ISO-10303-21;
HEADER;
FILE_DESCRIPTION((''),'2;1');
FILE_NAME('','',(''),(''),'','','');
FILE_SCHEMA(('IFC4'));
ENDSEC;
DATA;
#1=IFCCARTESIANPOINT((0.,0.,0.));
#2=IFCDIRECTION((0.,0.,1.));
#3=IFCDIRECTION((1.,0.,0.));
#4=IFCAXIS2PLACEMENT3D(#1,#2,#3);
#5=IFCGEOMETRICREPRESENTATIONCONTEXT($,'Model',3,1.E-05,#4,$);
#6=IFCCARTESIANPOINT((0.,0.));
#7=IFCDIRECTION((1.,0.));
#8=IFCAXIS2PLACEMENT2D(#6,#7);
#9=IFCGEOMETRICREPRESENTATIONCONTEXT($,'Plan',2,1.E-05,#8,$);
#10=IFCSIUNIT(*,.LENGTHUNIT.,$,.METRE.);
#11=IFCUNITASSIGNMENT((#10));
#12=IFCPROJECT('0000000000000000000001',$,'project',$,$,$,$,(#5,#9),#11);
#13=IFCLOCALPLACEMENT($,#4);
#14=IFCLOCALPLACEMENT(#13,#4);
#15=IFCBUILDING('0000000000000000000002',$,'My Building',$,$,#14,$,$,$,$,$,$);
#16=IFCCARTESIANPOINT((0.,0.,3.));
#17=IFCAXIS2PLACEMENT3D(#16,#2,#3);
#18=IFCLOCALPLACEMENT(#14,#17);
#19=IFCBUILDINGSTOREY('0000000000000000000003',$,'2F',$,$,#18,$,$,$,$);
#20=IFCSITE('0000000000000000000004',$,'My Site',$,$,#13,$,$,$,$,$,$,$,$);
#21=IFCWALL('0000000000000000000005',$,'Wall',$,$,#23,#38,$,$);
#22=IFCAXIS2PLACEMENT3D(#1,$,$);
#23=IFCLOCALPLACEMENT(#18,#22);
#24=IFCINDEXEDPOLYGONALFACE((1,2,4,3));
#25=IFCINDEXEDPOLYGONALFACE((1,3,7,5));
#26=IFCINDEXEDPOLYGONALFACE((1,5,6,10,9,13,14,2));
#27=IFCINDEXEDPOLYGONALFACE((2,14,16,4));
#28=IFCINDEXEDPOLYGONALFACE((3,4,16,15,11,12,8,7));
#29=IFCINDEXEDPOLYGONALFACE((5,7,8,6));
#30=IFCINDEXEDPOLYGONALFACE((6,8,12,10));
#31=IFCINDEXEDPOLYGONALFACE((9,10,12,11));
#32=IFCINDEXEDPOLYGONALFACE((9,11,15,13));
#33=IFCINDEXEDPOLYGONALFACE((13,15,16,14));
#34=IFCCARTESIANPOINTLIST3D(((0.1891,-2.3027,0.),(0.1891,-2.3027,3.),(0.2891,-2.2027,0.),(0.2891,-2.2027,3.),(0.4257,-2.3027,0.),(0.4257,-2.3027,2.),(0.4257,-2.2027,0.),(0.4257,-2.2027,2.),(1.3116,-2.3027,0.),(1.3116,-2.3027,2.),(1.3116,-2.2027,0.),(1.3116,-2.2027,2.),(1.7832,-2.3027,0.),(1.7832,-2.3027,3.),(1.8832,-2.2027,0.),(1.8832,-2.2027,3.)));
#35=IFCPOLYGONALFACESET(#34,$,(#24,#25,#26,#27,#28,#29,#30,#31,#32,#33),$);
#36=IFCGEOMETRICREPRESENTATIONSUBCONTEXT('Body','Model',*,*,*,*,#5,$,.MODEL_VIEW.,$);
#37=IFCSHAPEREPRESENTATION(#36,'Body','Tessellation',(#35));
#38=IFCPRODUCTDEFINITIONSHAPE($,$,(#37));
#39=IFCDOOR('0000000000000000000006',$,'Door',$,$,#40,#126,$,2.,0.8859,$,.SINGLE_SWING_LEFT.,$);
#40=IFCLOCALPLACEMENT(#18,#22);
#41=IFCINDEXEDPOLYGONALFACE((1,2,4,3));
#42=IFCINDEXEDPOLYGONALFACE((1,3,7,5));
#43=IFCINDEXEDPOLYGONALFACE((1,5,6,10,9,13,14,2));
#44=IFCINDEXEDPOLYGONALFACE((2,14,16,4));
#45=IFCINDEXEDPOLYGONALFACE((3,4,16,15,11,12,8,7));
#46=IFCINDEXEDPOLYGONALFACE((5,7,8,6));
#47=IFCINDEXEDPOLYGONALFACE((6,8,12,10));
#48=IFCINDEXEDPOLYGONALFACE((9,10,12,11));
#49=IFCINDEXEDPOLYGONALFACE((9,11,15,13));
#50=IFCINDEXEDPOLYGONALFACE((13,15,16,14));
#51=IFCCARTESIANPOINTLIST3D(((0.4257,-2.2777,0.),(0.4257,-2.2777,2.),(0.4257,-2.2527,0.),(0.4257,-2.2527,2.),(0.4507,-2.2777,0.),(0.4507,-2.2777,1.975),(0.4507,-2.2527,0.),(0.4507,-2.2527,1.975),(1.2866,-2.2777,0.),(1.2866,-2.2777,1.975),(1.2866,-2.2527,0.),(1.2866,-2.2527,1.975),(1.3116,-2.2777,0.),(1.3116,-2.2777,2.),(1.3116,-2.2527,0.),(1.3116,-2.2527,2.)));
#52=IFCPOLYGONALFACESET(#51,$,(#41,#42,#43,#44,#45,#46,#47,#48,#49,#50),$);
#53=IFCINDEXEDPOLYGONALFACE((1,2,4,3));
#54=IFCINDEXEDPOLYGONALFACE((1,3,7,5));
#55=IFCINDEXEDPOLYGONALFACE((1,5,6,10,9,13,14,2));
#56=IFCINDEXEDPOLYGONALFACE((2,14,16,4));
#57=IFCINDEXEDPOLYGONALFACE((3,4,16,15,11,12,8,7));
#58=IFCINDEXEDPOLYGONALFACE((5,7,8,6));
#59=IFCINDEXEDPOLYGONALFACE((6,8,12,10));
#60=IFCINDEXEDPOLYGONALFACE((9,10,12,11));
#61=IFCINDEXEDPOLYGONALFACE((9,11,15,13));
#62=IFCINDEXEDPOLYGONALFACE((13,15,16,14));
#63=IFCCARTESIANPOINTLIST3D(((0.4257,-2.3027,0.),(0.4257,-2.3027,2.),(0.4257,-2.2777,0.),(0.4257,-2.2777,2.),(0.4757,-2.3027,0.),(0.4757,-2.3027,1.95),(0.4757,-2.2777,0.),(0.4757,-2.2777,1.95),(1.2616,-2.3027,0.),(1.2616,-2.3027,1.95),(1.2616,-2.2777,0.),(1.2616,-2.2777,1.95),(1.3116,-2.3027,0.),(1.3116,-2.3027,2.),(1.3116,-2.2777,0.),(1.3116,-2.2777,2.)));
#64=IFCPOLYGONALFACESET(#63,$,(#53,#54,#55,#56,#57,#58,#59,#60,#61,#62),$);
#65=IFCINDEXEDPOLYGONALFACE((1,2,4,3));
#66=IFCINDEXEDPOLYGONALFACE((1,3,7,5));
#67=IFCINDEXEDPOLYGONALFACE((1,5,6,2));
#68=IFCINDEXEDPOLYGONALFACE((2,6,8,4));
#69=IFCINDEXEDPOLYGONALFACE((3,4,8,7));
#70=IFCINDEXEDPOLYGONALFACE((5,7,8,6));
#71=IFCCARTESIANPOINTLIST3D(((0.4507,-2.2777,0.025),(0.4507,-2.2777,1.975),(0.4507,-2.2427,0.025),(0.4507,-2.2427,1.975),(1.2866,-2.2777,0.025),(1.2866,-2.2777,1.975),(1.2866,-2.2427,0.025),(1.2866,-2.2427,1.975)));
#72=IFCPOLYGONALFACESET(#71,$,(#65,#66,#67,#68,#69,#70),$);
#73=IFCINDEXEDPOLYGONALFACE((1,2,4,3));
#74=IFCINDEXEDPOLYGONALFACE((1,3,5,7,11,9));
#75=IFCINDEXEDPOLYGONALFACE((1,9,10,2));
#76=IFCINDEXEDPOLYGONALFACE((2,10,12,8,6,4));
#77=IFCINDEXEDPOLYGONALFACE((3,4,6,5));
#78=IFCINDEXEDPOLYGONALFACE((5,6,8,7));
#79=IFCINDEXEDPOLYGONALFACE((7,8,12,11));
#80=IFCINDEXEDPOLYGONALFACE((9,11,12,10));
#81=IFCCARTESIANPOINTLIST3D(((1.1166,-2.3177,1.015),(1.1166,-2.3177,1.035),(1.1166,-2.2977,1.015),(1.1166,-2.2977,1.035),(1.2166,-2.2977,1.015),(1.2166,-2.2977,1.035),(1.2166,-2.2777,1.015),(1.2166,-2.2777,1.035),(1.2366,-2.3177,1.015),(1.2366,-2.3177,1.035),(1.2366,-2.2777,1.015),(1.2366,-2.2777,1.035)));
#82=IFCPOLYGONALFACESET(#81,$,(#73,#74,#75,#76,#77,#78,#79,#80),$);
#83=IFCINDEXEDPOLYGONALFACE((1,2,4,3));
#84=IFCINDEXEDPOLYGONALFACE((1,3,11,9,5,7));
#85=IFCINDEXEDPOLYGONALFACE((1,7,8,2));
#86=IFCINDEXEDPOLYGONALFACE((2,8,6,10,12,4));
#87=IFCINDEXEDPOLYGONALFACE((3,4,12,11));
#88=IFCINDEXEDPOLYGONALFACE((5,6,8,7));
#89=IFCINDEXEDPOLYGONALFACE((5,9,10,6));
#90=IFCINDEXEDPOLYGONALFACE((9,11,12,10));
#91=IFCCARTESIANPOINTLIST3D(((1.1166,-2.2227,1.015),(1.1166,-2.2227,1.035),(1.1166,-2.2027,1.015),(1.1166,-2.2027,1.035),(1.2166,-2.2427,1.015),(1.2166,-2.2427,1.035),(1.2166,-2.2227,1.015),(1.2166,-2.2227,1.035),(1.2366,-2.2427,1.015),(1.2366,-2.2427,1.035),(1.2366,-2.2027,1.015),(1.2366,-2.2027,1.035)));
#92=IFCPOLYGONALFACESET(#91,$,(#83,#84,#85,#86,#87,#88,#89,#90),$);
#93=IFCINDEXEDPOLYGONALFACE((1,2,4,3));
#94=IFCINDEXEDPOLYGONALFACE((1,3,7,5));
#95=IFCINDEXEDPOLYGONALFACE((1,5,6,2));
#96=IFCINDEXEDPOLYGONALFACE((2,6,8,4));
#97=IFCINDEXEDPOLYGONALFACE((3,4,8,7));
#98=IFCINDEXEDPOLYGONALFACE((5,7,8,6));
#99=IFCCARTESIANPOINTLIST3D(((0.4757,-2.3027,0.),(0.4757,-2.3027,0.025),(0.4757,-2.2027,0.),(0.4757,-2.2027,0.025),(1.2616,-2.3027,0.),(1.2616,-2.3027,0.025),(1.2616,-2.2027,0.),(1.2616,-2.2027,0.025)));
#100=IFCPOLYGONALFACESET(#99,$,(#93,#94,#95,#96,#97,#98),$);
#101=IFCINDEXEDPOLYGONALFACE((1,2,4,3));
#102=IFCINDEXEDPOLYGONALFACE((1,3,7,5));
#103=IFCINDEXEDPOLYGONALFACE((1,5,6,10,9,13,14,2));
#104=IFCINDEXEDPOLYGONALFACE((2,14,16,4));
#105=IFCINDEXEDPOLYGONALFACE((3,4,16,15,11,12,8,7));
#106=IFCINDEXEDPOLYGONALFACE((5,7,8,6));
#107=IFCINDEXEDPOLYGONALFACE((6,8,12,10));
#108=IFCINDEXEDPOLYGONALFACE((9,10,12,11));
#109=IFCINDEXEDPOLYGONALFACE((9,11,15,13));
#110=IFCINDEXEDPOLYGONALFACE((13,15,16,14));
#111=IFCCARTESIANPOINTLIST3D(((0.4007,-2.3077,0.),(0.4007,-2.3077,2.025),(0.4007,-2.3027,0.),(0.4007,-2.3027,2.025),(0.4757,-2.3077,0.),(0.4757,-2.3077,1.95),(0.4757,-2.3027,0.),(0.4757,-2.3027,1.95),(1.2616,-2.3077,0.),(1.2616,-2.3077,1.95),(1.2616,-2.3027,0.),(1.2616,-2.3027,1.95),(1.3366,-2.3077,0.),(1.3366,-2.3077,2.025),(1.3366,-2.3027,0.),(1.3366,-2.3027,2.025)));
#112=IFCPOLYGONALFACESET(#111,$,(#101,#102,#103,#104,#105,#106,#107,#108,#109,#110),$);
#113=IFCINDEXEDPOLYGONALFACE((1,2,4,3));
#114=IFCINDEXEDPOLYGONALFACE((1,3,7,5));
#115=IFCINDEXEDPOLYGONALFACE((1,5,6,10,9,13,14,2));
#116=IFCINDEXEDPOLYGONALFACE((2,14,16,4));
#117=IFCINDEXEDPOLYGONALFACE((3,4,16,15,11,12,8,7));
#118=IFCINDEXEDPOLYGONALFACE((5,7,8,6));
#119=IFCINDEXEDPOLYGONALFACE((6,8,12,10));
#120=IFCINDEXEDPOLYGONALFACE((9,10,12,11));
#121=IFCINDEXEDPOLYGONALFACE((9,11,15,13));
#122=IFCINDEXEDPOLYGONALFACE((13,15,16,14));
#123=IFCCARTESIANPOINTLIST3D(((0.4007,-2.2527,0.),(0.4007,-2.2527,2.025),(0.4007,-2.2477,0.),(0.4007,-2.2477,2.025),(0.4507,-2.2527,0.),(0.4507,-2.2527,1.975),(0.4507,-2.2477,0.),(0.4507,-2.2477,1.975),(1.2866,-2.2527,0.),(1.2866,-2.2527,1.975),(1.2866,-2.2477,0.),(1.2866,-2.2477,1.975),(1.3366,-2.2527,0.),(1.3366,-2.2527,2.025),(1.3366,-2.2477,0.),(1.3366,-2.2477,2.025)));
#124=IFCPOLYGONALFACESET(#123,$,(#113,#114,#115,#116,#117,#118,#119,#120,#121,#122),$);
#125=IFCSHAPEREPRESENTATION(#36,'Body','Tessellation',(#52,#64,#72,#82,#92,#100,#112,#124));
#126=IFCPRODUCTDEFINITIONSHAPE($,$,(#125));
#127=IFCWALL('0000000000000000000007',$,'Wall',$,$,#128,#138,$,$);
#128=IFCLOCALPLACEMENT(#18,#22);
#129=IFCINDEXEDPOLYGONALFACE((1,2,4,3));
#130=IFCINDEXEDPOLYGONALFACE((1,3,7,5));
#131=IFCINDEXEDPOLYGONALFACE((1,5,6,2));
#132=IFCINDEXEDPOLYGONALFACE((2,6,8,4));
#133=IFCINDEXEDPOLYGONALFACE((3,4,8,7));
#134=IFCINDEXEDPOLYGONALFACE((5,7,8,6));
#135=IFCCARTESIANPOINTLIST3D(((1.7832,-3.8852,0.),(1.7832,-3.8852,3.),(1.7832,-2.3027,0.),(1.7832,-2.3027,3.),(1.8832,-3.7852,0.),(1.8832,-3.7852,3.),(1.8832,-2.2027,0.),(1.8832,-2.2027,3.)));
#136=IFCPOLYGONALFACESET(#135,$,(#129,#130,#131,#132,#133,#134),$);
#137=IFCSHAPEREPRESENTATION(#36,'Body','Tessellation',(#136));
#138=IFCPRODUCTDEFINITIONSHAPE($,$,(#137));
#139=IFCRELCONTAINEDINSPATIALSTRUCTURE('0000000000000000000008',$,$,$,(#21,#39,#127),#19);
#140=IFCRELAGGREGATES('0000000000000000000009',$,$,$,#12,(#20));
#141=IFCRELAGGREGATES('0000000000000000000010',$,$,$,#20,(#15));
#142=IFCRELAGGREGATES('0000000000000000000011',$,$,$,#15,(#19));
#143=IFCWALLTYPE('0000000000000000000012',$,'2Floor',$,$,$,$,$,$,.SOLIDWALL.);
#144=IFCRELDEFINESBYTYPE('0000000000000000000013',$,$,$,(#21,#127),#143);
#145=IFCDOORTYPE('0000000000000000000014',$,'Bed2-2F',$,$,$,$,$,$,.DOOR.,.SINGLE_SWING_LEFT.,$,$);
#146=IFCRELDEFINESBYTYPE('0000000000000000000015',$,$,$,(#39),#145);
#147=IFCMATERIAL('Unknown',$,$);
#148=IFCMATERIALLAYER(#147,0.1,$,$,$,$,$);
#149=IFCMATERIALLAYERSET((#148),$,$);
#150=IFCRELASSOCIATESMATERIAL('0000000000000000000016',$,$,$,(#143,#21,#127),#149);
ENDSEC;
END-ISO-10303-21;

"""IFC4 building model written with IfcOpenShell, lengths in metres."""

from ifc_helpers import new_model, entity, si_unit, frame, origin_with_axes, origin_2d_with_axis, place, context, subcontext, project, spatial, line, indexed_curve, outline, extrude, shape, source, transform, mapped, material, layer, layer_set, layer_usage, type_object, type_shapes, element, fill, save


model = new_model("IFC4")

# Units and contexts
model_context = context("Model", 3, precision=1e-05, world=origin_with_axes())
plan_context = context("Plan", 2, precision=1e-05, world=origin_2d_with_axis())
body_context_1 = subcontext(model_context, "Body", "Model", "MODEL_VIEW")
body_context_2 = subcontext(plan_context, "Body", "Plan", "PLAN_VIEW")
ifc_project = project(units=[si_unit("LENGTHUNIT", "METRE")], contexts=[model_context, plan_context])

# Site, building, storey
site_placement = place(None, origin_with_axes())
site = spatial("IfcSite", under=ifc_project, at=site_placement, Name="My Site")
building_placement = place(site_placement, origin_with_axes())
building = spatial("IfcBuilding", under=site, at=building_placement, Name="My Building")
storey_placement = place(building_placement, frame((0.0, 0.0, 3.0), z_axis=(0.0, 0.0, 1.0), x_axis=(1.0, 0.0, 0.0)))
storey = spatial("IfcBuildingStorey", under=building, at=storey_placement, Name="2F")

# Shared definitions
ifc_material = material(Name="Unknown")

# Shared definitions
ifc_layer_1 = layer(ifc_material, 0.1)
ifc_layer_set_1 = layer_set([ifc_layer_1])
wall_type = type_object("IfcWallType", Name="2Floor", PredefinedType="SOLIDWALL", material=ifc_layer_set_1)

# Wall, opening, door
ifc_layer_usage_1 = layer_usage(ifc_layer_set_1, "AXIS2", "POSITIVE", 0.0)
wall_1_placement = place(storey_placement, frame((0.1891, -2.3027, 0.0), z_axis=(0.0, 0.0, 1.0), x_axis=(1.0, 0.0, 0.0)))
wall_1 = element("IfcWall", 1, at=wall_1_placement, inside=storey, type_object=wall_type, material=ifc_layer_usage_1, Name="Wall", context=body_context_1, shape_type="SweptSolid", body=[
    extrude(outline(indexed_curve([(0.0, 0.0), (0.1, 0.1), (1.6941, 0.1), (1.5941, 0.0)], segments=[line(1, 2, 3, 4, 1)])), origin_with_axes(), (0.0, 0.0, 1.0), 3.0),
])
shared_shape_1 = source(origin_with_axes(), body_context_1, "Body", "SweptSolid", [
    extrude(outline(indexed_curve([(0.0, 0.0), (0.8859, 0.0), (0.8859, 2.0), (0.0, 2.0)], segments=[line(1, 2, 3, 4, 1)])), frame((0.0, -0.6, 0.0), z_axis=(0.0, -1.0, 0.0), x_axis=(1.0, 0.0, 0.0)), (0.0, 0.0, -1.0), 1.2),
])
opening_1_placement = place(wall_1_placement, frame((0.2366, 0.0, 0.0), z_axis=(0.0, 0.0, 1.0), x_axis=(1.0, 0.0, 0.0)))
opening_1 = element("IfcOpeningElement", 2, at=opening_1_placement, cuts=wall_1, PredefinedType="OPENING", context=body_context_1, shape_type="MappedRepresentation", body=[
    mapped(shared_shape_1, transform((0.0, 0.0, 0.0), x_axis=(1.0, 0.0, 0.0), y_axis=(0.0, 1.0, 0.0), z_axis=(0.0, 0.0, 1.0), scale=1.0)),
])
door_type_1 = type_object("IfcDoorType", Name="Bed2-2F", OperationType="SINGLE_SWING_LEFT", PredefinedType="DOOR")
shared_shape_2 = source(origin_with_axes(), body_context_1, "Body", "SweptSolid", [
    extrude(outline(indexed_curve([(0.0, 0.0), (0.0, 2.0), (0.8859, 2.0), (0.8859, 0.0), (0.8609, 0.0), (0.8609, 1.975), (0.025, 1.975), (0.025, 0.0)], segments=[line(1, 2, 3, 4, 5, 6, 7, 8, 1)])), frame((0.0, 0.025, 0.0), z_axis=(0.0, -1.0, 0.0), x_axis=(1.0, 0.0, 0.0)), (0.0, 0.0, -1.0), 0.025),
    extrude(outline(indexed_curve([(0.0, 0.0), (0.0, 2.0), (0.8859, 2.0), (0.8859, 0.0), (0.8359, 0.0), (0.8359, 1.95), (0.05, 1.95), (0.05, 0.0)], segments=[line(1, 2, 3, 4, 5, 6, 7, 8, 1)])), frame((0.0, 0.0, 0.0), z_axis=(0.0, -1.0, 0.0), x_axis=(1.0, 0.0, 0.0)), (0.0, 0.0, -1.0), 0.025),
    extrude(outline(indexed_curve([(0.0, 0.0), (0.8359, 0.0), (0.8359, 0.035), (0.0, 0.035)], segments=[line(1, 2, 3, 4, 1)])), frame((0.025, 0.025, 0.025), z_axis=(0.0, 0.0, 1.0), x_axis=(1.0, 0.0, 0.0)), (0.0, 0.0, 1.0), 1.95),
    extrude(outline(indexed_curve([(0.0, 0.0), (0.0, -0.04), (-0.12, -0.04), (-0.12, -0.02), (-0.02, -0.02), (-0.02, 0.0)], segments=[line(1, 2, 3, 4, 5, 6, 1)])), frame((0.8109, 0.025, 1.015), z_axis=(0.0, 0.0, 1.0), x_axis=(1.0, 0.0, 0.0)), (0.0, 0.0, 1.0), 0.02),
    extrude(outline(indexed_curve([(0.0, 0.0), (0.0, 0.04), (-0.12, 0.04), (-0.12, 0.02), (-0.02, 0.02), (-0.02, 0.0)], segments=[line(1, 2, 3, 4, 5, 6, 1)])), frame((0.8109, 0.06, 1.015), z_axis=(0.0, 0.0, 1.0), x_axis=(1.0, 0.0, 0.0)), (0.0, 0.0, 1.0), 0.02),
    extrude(outline(indexed_curve([(0.0, 0.0), (0.7859, 0.0), (0.7859, 0.1), (0.0, 0.1)], segments=[line(1, 2, 3, 4, 1)])), frame((0.05, 0.0, 0.0), z_axis=(0.0, 0.0, 1.0), x_axis=(1.0, 0.0, 0.0)), (0.0, 0.0, 1.0), 0.025),
    extrude(outline(indexed_curve([(0.0, 0.0), (0.0, 2.025), (0.9359, 2.025), (0.9359, 0.0), (0.8609, 0.0), (0.8609, 1.95), (0.075, 1.95), (0.075, 0.0)], segments=[line(1, 2, 3, 4, 5, 6, 7, 8, 1)])), frame((-0.025, -0.005, 0.0), z_axis=(0.0, -1.0, 0.0), x_axis=(1.0, 0.0, 0.0)), (0.0, 0.0, -1.0), 0.005),
    extrude(outline(indexed_curve([(0.0, 0.0), (0.0, 2.025), (0.9359, 2.025), (0.9359, 0.0), (0.8859, 0.0), (0.8859, 1.975), (0.05, 1.975), (0.05, 0.0)], segments=[line(1, 2, 3, 4, 5, 6, 7, 8, 1)])), frame((-0.025, 0.05, 0.0), z_axis=(0.0, -1.0, 0.0), x_axis=(1.0, 0.0, 0.0)), (0.0, 0.0, -1.0), 0.005),
])
shared_shape_3 = source(origin_with_axes(), body_context_2, "Body", "Curve2D", [
    entity("IfcIndexedPolyCurve", entity("IfcCartesianPointList2D", [[0.0, 0.0], [0.0, 0.05], [0.025, 0.05], [0.025, 0.025], [0.05, 0.025], [0.05, 0.0]]), [entity("IfcLineIndex", [1, 2, 3, 4, 5, 6, 1])]),
    entity("IfcIndexedPolyCurve", entity("IfcCartesianPointList2D", [[0.8859, 0.0], [0.8859, 0.05], [0.8609, 0.05], [0.8609, 0.025], [0.8359, 0.025], [0.8359, 0.0]]), [entity("IfcLineIndex", [1, 2, 3, 4, 5, 6, 1])]),
    entity("IfcTrimmedCurve", entity("IfcEllipse", entity("IfcAxis2Placement2D", entity("IfcCartesianPoint", [0.06, 0.05]), entity("IfcDirection", [1.0, 0.0])), 0.8009, 0.8359), [entity("IfcCartesianPoint", [0.8609, 0.05])], [entity("IfcCartesianPoint", [0.06, 0.8859])], True, "CARTESIAN"),
    entity("IfcIndexedPolyCurve", entity("IfcCartesianPointList2D", [[0.025, 0.05], [0.06, 0.05], [0.06, 0.8859], [0.025, 0.8859]]), [entity("IfcLineIndex", [1, 2, 3, 4, 1])]),
])
type_shapes(door_type_1, [shared_shape_2, shared_shape_3])
door_1_placement = place(opening_1_placement, frame((0.0, 0.0, 0.0), z_axis=(0.0, 0.0, 1.0), x_axis=(1.0, 0.0, 0.0)))
door_1 = element("IfcDoor", 3, at=door_1_placement, inside=storey, type_object=door_type_1, Name="Door", OperationType="SINGLE_SWING_LEFT", OverallHeight=2.0, OverallWidth=0.8859, shapes=[
    shape(body_context_1, "Body", "MappedRepresentation", [mapped(shared_shape_2, transform((0.0, 0.0, 0.0), x_axis=(1.0, 0.0, 0.0), y_axis=(0.0, 1.0, 0.0), z_axis=(0.0, 0.0, 1.0), scale=1.0))]),
    shape(body_context_2, "Body", "MappedRepresentation", [mapped(shared_shape_3, transform((0.0, 0.0, 0.0), x_axis=(1.0, 0.0, 0.0), y_axis=(0.0, 1.0, 0.0), z_axis=(0.0, 0.0, 1.0), scale=1.0))]),
])
fill(opening_1, door_1)

# Wall
ifc_layer_usage_2 = layer_usage(ifc_layer_set_1, "AXIS2", "POSITIVE", 0.0)
wall_2_placement = place(storey_placement, frame((1.7832, -2.3027, 0.0), z_axis=(0.0, 0.0, 1.0), x_axis=(0.0, -1.0, 0.0)))
element("IfcWall", 4, at=wall_2_placement, inside=storey, type_object=wall_type, material=ifc_layer_usage_2, Name="Wall", context=body_context_1, shape_type="SweptSolid", body=[
    extrude(outline(indexed_curve([(0.0, 0.0), (-0.1, 0.1), (1.4825, 0.1), (1.5825, 0.0)], segments=[line(1, 2, 3, 4, 1)])), origin_with_axes(), (0.0, 0.0, 1.0), 3.0),
])

save(model, "model.ifc")
